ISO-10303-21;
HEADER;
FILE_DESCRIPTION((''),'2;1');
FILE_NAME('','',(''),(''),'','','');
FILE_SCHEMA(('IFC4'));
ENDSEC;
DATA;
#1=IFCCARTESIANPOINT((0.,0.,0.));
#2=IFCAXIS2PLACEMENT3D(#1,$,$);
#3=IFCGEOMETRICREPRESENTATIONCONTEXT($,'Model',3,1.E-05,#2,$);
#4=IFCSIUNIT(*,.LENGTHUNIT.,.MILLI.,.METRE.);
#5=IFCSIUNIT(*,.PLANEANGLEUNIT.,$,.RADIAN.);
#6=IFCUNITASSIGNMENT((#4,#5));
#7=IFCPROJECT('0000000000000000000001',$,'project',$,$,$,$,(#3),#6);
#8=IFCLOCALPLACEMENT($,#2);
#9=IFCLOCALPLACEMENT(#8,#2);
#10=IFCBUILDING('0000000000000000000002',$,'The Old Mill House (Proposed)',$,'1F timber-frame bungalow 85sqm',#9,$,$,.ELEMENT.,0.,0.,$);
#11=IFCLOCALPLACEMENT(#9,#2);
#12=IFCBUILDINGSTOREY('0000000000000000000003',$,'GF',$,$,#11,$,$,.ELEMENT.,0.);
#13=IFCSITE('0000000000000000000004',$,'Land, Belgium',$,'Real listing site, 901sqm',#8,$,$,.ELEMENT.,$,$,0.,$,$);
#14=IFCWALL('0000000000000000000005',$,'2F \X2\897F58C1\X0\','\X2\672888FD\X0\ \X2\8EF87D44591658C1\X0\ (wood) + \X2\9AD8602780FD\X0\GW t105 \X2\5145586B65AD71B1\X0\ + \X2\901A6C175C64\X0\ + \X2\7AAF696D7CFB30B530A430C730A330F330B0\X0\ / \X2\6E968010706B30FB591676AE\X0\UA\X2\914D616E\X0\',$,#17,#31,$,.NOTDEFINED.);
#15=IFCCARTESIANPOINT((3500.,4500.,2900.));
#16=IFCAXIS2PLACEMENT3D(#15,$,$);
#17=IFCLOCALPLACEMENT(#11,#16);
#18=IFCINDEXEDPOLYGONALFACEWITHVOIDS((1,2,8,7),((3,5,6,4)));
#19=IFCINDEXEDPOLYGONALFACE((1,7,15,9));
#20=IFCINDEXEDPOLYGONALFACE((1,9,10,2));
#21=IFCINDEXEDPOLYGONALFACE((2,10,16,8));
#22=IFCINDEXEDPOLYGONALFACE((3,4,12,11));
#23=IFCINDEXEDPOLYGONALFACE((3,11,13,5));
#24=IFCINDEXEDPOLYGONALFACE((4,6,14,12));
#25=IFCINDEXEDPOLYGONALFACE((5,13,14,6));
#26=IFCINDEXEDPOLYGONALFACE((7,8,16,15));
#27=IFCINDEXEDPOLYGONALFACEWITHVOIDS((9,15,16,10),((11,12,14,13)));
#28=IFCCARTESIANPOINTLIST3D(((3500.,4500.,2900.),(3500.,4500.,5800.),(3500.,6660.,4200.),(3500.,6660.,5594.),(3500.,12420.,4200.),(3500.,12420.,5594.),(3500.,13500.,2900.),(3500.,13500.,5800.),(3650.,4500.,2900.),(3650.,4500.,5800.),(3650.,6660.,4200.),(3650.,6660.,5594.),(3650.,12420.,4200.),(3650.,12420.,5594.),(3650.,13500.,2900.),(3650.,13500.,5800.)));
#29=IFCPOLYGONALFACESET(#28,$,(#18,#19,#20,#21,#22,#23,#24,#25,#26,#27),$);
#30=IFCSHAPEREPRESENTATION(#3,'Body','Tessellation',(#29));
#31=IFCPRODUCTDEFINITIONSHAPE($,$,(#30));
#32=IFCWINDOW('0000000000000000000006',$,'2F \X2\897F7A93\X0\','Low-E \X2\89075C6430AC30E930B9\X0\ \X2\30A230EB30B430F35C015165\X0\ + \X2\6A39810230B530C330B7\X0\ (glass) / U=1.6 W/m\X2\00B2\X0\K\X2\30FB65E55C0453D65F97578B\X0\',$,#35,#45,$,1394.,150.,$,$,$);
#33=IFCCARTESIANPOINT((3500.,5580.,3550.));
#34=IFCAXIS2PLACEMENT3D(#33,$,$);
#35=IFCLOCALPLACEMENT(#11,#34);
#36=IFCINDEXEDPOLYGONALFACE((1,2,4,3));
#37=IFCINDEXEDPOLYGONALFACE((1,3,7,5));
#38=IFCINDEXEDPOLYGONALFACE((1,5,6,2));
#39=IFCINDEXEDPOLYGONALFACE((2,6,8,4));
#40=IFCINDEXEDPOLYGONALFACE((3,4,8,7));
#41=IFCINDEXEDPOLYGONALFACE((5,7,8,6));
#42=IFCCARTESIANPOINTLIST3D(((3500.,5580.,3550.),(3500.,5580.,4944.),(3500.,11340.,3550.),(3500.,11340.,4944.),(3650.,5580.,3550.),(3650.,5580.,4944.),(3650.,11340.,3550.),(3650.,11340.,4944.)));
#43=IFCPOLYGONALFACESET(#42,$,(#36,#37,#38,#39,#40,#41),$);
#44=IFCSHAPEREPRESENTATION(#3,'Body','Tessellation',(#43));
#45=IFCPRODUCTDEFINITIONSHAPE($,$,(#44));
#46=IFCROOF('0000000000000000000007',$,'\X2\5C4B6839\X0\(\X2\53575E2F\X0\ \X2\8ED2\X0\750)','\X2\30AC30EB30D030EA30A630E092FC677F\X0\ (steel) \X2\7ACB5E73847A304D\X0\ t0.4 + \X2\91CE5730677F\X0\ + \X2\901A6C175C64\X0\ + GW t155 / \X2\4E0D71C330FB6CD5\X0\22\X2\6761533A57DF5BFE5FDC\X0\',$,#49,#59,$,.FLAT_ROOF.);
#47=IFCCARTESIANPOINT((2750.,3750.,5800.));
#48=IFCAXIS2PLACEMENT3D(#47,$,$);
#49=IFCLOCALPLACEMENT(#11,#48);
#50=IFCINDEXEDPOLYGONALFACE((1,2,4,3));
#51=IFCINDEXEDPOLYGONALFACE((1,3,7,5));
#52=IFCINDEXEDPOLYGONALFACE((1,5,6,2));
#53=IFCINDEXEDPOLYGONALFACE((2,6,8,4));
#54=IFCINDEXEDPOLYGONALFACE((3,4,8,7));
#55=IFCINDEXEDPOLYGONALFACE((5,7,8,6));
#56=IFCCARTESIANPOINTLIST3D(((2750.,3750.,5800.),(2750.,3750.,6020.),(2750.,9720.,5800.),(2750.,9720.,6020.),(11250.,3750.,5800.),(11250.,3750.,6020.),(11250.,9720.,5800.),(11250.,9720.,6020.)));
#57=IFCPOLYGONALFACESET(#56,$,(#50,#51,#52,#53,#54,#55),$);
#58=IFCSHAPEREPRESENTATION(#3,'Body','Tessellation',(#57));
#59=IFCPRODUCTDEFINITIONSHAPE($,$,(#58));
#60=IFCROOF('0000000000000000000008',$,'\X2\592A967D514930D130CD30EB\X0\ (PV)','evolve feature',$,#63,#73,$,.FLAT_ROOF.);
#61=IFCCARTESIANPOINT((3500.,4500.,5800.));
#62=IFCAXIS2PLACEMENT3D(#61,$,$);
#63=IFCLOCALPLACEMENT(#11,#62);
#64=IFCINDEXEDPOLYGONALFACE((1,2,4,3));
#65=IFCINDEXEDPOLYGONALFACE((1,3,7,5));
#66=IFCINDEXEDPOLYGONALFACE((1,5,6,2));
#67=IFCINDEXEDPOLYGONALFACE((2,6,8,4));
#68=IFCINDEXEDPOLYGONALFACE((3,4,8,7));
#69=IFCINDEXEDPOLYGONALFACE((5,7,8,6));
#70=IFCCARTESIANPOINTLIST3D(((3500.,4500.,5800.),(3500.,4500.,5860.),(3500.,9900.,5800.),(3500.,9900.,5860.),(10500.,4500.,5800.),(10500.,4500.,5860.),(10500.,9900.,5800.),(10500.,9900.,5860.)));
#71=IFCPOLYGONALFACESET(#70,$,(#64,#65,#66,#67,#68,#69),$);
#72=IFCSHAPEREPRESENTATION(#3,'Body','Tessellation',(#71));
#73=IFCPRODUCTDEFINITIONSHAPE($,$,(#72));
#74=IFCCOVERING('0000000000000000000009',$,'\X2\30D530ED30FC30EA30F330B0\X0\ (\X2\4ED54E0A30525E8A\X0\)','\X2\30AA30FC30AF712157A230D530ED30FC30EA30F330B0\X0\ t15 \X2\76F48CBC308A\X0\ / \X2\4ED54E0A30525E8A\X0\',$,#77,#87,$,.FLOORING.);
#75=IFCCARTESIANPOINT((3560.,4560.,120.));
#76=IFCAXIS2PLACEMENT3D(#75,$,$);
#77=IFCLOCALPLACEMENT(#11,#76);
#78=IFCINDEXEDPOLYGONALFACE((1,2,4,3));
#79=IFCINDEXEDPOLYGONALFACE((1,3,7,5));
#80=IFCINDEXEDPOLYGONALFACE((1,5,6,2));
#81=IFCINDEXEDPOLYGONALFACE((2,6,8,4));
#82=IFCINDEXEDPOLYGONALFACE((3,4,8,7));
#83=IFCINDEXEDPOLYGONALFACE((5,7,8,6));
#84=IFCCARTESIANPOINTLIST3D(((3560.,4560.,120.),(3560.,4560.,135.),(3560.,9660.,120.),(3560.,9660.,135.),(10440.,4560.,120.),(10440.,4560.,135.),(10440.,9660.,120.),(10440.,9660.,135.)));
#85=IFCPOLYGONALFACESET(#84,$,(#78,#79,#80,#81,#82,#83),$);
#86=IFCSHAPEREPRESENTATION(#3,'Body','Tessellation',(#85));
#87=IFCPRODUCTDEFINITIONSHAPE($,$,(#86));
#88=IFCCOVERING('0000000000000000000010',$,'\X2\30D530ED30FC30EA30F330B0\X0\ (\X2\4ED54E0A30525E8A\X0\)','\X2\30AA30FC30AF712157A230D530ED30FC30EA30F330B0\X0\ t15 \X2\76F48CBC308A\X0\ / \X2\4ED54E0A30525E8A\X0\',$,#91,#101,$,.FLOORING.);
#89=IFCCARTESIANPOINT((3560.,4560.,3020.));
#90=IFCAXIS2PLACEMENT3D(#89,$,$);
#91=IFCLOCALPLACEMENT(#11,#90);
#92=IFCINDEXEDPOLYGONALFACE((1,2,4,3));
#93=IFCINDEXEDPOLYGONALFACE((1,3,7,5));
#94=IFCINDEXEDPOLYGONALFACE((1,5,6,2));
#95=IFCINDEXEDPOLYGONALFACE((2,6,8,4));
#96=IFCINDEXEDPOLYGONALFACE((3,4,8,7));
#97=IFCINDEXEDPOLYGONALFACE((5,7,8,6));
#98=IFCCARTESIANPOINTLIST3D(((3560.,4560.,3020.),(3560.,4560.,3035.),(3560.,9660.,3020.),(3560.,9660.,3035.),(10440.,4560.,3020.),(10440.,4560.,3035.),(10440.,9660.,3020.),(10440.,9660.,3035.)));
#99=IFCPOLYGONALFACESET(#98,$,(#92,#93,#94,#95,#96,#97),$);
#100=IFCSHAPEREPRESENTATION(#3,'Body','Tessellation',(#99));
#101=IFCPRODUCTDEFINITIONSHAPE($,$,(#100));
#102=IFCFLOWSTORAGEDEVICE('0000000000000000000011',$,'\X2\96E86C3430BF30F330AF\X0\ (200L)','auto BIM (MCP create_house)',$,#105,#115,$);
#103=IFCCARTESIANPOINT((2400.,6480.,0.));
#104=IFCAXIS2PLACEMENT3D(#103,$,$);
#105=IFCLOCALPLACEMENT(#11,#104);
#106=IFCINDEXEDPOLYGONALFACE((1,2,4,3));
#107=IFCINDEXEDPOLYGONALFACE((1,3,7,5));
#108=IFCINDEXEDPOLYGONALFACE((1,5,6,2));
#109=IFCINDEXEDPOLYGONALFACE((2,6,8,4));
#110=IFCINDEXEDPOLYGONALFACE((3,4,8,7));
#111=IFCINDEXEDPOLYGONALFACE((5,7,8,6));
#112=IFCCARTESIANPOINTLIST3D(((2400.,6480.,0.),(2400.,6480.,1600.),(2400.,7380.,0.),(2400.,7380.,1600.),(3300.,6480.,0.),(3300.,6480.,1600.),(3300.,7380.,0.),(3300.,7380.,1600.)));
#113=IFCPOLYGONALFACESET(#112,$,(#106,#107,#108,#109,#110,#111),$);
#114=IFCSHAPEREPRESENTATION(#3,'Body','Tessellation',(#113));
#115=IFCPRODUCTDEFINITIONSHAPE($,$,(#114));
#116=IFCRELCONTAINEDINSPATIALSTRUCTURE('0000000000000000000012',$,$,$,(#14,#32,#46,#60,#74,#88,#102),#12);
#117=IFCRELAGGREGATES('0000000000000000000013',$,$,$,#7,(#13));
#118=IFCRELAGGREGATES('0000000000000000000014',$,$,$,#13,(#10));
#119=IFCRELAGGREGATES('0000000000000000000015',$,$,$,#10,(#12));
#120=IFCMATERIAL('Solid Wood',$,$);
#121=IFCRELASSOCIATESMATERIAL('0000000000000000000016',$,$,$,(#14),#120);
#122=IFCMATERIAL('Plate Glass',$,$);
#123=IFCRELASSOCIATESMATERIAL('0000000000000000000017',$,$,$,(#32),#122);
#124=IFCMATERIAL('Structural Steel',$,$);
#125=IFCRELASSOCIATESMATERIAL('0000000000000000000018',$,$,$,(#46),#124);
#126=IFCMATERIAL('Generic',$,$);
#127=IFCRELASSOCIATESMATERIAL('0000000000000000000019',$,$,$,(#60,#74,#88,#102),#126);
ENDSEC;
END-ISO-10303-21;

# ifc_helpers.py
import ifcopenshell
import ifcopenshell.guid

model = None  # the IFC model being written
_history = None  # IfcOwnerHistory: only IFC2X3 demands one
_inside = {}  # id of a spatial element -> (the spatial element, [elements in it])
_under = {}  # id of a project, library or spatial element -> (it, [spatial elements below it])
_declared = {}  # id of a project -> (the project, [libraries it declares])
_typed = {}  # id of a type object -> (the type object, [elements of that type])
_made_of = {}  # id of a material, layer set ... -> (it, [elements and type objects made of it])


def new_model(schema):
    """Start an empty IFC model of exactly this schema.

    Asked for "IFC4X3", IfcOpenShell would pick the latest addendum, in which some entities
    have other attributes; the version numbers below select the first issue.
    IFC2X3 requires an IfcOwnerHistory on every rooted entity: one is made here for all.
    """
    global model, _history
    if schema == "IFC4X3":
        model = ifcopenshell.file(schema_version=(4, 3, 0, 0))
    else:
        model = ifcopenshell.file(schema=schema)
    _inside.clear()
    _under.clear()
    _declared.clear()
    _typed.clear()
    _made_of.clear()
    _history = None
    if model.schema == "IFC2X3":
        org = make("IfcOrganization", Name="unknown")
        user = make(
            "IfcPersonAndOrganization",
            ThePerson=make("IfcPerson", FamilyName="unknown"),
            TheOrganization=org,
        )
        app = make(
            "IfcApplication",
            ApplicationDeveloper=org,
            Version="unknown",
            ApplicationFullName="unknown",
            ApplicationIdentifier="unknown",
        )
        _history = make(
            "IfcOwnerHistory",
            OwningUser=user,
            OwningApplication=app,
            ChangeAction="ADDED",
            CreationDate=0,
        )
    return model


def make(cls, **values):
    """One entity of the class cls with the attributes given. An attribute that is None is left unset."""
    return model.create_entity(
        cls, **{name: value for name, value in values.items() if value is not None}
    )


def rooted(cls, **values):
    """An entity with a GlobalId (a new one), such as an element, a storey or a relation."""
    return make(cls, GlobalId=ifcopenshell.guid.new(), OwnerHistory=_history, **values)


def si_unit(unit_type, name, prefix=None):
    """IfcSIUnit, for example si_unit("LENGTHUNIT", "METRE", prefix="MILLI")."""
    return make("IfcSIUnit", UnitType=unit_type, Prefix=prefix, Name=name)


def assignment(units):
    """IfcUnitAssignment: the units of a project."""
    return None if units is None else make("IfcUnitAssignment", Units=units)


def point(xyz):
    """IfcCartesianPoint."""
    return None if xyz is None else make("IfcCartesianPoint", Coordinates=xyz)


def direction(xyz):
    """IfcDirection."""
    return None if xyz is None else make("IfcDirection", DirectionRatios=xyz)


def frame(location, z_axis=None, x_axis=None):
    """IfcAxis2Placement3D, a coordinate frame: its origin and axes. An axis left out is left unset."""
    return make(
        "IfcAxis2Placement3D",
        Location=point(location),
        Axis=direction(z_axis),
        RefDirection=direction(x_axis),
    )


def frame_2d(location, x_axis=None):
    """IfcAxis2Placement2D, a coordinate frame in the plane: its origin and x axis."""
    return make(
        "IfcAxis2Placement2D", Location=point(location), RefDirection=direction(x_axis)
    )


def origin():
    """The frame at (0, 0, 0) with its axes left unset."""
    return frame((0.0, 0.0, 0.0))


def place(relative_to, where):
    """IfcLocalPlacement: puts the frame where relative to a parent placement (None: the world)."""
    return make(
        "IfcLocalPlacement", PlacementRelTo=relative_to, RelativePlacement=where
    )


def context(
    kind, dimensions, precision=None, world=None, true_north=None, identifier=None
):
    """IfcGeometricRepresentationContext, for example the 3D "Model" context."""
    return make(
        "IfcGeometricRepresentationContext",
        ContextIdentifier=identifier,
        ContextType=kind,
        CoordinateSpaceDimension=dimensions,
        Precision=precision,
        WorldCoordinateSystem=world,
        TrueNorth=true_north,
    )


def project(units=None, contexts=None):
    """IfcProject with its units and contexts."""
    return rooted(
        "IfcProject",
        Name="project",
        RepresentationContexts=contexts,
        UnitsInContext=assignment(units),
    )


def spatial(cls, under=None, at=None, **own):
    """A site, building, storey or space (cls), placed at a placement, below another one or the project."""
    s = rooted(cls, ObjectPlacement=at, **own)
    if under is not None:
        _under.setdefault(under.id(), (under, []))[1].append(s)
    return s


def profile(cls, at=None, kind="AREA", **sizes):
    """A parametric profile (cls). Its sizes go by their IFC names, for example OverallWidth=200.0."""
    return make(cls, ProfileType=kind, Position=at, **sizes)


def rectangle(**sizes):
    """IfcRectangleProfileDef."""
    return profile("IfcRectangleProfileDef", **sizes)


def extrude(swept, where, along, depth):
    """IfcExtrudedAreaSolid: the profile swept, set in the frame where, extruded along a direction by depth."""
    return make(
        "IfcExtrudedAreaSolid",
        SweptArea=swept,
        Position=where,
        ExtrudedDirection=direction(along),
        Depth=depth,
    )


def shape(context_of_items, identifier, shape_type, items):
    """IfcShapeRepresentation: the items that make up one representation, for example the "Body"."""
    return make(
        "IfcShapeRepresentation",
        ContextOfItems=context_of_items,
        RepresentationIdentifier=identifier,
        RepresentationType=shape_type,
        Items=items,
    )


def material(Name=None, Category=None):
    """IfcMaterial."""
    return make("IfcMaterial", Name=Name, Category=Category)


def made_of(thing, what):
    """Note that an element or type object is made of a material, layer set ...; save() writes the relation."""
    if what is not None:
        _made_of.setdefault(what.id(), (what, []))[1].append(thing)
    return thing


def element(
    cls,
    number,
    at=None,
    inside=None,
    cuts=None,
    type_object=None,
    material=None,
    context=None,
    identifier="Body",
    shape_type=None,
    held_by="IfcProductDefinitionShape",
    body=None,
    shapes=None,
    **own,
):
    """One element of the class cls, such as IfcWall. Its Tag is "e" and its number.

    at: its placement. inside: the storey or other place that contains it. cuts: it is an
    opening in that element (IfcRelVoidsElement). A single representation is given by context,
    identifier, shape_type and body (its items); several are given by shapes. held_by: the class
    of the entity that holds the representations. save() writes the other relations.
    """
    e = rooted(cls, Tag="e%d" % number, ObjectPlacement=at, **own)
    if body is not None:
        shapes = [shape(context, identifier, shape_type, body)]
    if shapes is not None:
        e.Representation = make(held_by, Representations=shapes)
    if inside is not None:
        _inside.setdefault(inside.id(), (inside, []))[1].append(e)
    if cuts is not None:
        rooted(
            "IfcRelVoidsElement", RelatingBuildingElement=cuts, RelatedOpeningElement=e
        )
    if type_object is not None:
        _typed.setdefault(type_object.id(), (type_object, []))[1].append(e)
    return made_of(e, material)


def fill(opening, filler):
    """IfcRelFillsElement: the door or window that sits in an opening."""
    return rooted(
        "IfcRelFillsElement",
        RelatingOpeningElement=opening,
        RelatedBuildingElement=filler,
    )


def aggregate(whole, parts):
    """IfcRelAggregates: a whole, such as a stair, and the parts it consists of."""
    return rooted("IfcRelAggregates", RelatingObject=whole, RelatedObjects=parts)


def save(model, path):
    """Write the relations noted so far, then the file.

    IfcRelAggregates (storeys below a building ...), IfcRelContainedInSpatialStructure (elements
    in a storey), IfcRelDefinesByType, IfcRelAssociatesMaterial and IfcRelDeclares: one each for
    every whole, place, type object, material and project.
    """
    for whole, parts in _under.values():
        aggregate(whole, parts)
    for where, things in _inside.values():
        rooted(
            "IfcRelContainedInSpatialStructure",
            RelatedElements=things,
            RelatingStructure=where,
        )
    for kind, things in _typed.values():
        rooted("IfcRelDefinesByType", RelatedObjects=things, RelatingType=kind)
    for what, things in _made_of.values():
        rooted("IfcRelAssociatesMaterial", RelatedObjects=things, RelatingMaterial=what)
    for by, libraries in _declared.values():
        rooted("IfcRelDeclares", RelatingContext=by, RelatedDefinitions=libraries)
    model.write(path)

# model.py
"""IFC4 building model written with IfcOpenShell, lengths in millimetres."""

from ifc_helpers import new_model, si_unit, frame, frame_2d, origin, place, context, project, spatial, rectangle, extrude, material, element, fill, save


model = new_model("IFC4")

# Units and contexts
model_context = context("Model", 3, precision=1e-05, world=origin())
ifc_project = project(units=[si_unit("LENGTHUNIT", "METRE", prefix="MILLI"), si_unit("PLANEANGLEUNIT", "RADIAN")], contexts=[model_context])

# Site, building, storey
site_placement = place(None, origin())
site = spatial("IfcSite", under=ifc_project, at=site_placement, Name="Land, Belgium", ObjectType="Real listing site, 901sqm", CompositionType="ELEMENT", RefElevation=0.0)
building_placement = place(site_placement, origin())
building = spatial("IfcBuilding", under=site, at=building_placement, Name="The Old Mill House (Proposed)", ObjectType="1F timber-frame bungalow 85sqm", CompositionType="ELEMENT", ElevationOfRefHeight=0.0, ElevationOfTerrain=0.0)
storey_placement = place(building_placement, origin())
storey = spatial("IfcBuildingStorey", under=building, at=storey_placement, Name="GF", CompositionType="ELEMENT", Elevation=0.0)

# Shared definitions
ifc_material_1 = material(Name="Solid Wood")
ifc_material_2 = material(Name="Generic")

# Shared definitions
ifc_material_3 = material(Name="Plate Glass")

# Wall, opening, window
wall_1_placement = place(storey_placement, frame((3500.0, 4500.0, 2900.0)))
wall_1 = element("IfcWall", 1, at=wall_1_placement, inside=storey, material=ifc_material_1, Name="2F 西壁", Description="木製 軸組外壁 (wood) + 高性能GW t105 充填断熱 + 通気層 + 窯業系サイディング / 準耐火・外皮UA配慮", PredefinedType="NOTDEFINED", context=model_context, shape_type="SweptSolid", body=[
    extrude(rectangle(XDim=150.0, YDim=9000.0, at=frame_2d((75.0, 4500.0))), frame((3500.0, 4500.0, 2900.0)), (0.0, 0.0, 1.0), 2900.0),
])
opening_1_placement = place(storey_placement, frame((3500.0, 5580.0, 3550.0)))
opening_1 = element("IfcOpeningElement", 2, at=opening_1_placement, cuts=wall_1, PredefinedType="NOTDEFINED", context=model_context, shape_type="SweptSolid", body=[
    extrude(rectangle(XDim=150.0, YDim=5760.0, at=frame_2d((75.0, 2880.0))), frame((3500.0, 5580.0, 3550.0)), (0.0, 0.0, 1.0), 1394.0),
])
window_1_placement = place(storey_placement, frame((3500.0, 5580.0, 3550.0)))
window_1 = element("IfcWindow", 3, at=window_1_placement, inside=storey, material=ifc_material_3, Name="2F 西窓", Description="Low-E 複層ガラス アルゴン封入 + 樹脂サッシ (glass) / U=1.6 W/m²K・日射取得型", OverallHeight=1394.0, OverallWidth=150.0, context=model_context, shape_type="SweptSolid", body=[
    extrude(rectangle(XDim=150.0, YDim=5760.0, at=frame_2d((75.0, 2880.0))), frame((3500.0, 5580.0, 3550.0)), (0.0, 0.0, 1.0), 1394.0),
])
fill(opening_1, window_1)

# Roofs
ifc_material_4 = material(Name="Structural Steel")
for number, where, name in (
    (4, (2750.0, 3750.0, 5800.0), "屋根(南帯 軒750)"),
):
    element("IfcRoof", number, at=place(storey_placement, frame(where)), inside=storey, material=ifc_material_4, Name=name, Description="ガルバリウム鋼板 (steel) 立平葺き t0.4 + 野地板 + 通気層 + GW t155 / 不燃・法22条区域対応", PredefinedType="FLAT_ROOF", context=model_context, shape_type="SweptSolid", body=[
        extrude(rectangle(XDim=8500.0, YDim=5970.0, at=frame_2d((4250.0, 2985.0))), frame((2750.0, 3750.0, 5800.0)), (0.0, 0.0, 1.0), 220.0),
    ])
roof_placement = place(storey_placement, frame((3500.0, 4500.0, 5800.0)))
element("IfcRoof", 5, at=roof_placement, inside=storey, material=ifc_material_2, Name="太陽光パネル (PV)", Description="evolve feature", PredefinedType="FLAT_ROOF", context=model_context, shape_type="SweptSolid", body=[
    extrude(rectangle(XDim=7000.0, YDim=5400.0, at=frame_2d((3500.0, 2700.0))), frame((3500.0, 4500.0, 5800.0)), (0.0, 0.0, 1.0), 60.0),
])

# Coverings
covering_1_placement = place(storey_placement, frame((3560.0, 4560.0, 120.0)))
element("IfcCovering", 6, at=covering_1_placement, inside=storey, material=ifc_material_2, Name="フローリング (仕上げ床)", Description="オーク無垢フローリング t15 直貼り / 仕上げ床", PredefinedType="FLOORING", context=model_context, shape_type="SweptSolid", body=[
    extrude(rectangle(XDim=6880.0, YDim=5100.0, at=frame_2d((3440.0, 2550.0))), frame((3560.0, 4560.0, 120.0)), (0.0, 0.0, 1.0), 15.0),
])
covering_2_placement = place(storey_placement, frame((3560.0, 4560.0, 3020.0)))
element("IfcCovering", 7, at=covering_2_placement, inside=storey, material=ifc_material_2, Name="フローリング (仕上げ床)", Description="オーク無垢フローリング t15 直貼り / 仕上げ床", PredefinedType="FLOORING", context=model_context, shape_type="SweptSolid", body=[
    extrude(rectangle(XDim=6880.0, YDim=5100.0, at=frame_2d((3440.0, 2550.0))), frame((3560.0, 4560.0, 3020.0)), (0.0, 0.0, 1.0), 15.0),
])

# Flow storage device
flow_storage_device_placement = place(storey_placement, frame((2400.0, 6480.0, 0.0)))
element("IfcFlowStorageDevice", 8, at=flow_storage_device_placement, inside=storey, material=ifc_material_2, Name="雨水タンク (200L)", Description="auto BIM (MCP create_house)", context=model_context, shape_type="SweptSolid", body=[
    extrude(rectangle(XDim=900.0, YDim=900.0, at=frame_2d((450.0, 450.0))), frame((2400.0, 6480.0, 0.0)), (0.0, 0.0, 1.0), 1600.0),
])

save(model, "model.ifc")
